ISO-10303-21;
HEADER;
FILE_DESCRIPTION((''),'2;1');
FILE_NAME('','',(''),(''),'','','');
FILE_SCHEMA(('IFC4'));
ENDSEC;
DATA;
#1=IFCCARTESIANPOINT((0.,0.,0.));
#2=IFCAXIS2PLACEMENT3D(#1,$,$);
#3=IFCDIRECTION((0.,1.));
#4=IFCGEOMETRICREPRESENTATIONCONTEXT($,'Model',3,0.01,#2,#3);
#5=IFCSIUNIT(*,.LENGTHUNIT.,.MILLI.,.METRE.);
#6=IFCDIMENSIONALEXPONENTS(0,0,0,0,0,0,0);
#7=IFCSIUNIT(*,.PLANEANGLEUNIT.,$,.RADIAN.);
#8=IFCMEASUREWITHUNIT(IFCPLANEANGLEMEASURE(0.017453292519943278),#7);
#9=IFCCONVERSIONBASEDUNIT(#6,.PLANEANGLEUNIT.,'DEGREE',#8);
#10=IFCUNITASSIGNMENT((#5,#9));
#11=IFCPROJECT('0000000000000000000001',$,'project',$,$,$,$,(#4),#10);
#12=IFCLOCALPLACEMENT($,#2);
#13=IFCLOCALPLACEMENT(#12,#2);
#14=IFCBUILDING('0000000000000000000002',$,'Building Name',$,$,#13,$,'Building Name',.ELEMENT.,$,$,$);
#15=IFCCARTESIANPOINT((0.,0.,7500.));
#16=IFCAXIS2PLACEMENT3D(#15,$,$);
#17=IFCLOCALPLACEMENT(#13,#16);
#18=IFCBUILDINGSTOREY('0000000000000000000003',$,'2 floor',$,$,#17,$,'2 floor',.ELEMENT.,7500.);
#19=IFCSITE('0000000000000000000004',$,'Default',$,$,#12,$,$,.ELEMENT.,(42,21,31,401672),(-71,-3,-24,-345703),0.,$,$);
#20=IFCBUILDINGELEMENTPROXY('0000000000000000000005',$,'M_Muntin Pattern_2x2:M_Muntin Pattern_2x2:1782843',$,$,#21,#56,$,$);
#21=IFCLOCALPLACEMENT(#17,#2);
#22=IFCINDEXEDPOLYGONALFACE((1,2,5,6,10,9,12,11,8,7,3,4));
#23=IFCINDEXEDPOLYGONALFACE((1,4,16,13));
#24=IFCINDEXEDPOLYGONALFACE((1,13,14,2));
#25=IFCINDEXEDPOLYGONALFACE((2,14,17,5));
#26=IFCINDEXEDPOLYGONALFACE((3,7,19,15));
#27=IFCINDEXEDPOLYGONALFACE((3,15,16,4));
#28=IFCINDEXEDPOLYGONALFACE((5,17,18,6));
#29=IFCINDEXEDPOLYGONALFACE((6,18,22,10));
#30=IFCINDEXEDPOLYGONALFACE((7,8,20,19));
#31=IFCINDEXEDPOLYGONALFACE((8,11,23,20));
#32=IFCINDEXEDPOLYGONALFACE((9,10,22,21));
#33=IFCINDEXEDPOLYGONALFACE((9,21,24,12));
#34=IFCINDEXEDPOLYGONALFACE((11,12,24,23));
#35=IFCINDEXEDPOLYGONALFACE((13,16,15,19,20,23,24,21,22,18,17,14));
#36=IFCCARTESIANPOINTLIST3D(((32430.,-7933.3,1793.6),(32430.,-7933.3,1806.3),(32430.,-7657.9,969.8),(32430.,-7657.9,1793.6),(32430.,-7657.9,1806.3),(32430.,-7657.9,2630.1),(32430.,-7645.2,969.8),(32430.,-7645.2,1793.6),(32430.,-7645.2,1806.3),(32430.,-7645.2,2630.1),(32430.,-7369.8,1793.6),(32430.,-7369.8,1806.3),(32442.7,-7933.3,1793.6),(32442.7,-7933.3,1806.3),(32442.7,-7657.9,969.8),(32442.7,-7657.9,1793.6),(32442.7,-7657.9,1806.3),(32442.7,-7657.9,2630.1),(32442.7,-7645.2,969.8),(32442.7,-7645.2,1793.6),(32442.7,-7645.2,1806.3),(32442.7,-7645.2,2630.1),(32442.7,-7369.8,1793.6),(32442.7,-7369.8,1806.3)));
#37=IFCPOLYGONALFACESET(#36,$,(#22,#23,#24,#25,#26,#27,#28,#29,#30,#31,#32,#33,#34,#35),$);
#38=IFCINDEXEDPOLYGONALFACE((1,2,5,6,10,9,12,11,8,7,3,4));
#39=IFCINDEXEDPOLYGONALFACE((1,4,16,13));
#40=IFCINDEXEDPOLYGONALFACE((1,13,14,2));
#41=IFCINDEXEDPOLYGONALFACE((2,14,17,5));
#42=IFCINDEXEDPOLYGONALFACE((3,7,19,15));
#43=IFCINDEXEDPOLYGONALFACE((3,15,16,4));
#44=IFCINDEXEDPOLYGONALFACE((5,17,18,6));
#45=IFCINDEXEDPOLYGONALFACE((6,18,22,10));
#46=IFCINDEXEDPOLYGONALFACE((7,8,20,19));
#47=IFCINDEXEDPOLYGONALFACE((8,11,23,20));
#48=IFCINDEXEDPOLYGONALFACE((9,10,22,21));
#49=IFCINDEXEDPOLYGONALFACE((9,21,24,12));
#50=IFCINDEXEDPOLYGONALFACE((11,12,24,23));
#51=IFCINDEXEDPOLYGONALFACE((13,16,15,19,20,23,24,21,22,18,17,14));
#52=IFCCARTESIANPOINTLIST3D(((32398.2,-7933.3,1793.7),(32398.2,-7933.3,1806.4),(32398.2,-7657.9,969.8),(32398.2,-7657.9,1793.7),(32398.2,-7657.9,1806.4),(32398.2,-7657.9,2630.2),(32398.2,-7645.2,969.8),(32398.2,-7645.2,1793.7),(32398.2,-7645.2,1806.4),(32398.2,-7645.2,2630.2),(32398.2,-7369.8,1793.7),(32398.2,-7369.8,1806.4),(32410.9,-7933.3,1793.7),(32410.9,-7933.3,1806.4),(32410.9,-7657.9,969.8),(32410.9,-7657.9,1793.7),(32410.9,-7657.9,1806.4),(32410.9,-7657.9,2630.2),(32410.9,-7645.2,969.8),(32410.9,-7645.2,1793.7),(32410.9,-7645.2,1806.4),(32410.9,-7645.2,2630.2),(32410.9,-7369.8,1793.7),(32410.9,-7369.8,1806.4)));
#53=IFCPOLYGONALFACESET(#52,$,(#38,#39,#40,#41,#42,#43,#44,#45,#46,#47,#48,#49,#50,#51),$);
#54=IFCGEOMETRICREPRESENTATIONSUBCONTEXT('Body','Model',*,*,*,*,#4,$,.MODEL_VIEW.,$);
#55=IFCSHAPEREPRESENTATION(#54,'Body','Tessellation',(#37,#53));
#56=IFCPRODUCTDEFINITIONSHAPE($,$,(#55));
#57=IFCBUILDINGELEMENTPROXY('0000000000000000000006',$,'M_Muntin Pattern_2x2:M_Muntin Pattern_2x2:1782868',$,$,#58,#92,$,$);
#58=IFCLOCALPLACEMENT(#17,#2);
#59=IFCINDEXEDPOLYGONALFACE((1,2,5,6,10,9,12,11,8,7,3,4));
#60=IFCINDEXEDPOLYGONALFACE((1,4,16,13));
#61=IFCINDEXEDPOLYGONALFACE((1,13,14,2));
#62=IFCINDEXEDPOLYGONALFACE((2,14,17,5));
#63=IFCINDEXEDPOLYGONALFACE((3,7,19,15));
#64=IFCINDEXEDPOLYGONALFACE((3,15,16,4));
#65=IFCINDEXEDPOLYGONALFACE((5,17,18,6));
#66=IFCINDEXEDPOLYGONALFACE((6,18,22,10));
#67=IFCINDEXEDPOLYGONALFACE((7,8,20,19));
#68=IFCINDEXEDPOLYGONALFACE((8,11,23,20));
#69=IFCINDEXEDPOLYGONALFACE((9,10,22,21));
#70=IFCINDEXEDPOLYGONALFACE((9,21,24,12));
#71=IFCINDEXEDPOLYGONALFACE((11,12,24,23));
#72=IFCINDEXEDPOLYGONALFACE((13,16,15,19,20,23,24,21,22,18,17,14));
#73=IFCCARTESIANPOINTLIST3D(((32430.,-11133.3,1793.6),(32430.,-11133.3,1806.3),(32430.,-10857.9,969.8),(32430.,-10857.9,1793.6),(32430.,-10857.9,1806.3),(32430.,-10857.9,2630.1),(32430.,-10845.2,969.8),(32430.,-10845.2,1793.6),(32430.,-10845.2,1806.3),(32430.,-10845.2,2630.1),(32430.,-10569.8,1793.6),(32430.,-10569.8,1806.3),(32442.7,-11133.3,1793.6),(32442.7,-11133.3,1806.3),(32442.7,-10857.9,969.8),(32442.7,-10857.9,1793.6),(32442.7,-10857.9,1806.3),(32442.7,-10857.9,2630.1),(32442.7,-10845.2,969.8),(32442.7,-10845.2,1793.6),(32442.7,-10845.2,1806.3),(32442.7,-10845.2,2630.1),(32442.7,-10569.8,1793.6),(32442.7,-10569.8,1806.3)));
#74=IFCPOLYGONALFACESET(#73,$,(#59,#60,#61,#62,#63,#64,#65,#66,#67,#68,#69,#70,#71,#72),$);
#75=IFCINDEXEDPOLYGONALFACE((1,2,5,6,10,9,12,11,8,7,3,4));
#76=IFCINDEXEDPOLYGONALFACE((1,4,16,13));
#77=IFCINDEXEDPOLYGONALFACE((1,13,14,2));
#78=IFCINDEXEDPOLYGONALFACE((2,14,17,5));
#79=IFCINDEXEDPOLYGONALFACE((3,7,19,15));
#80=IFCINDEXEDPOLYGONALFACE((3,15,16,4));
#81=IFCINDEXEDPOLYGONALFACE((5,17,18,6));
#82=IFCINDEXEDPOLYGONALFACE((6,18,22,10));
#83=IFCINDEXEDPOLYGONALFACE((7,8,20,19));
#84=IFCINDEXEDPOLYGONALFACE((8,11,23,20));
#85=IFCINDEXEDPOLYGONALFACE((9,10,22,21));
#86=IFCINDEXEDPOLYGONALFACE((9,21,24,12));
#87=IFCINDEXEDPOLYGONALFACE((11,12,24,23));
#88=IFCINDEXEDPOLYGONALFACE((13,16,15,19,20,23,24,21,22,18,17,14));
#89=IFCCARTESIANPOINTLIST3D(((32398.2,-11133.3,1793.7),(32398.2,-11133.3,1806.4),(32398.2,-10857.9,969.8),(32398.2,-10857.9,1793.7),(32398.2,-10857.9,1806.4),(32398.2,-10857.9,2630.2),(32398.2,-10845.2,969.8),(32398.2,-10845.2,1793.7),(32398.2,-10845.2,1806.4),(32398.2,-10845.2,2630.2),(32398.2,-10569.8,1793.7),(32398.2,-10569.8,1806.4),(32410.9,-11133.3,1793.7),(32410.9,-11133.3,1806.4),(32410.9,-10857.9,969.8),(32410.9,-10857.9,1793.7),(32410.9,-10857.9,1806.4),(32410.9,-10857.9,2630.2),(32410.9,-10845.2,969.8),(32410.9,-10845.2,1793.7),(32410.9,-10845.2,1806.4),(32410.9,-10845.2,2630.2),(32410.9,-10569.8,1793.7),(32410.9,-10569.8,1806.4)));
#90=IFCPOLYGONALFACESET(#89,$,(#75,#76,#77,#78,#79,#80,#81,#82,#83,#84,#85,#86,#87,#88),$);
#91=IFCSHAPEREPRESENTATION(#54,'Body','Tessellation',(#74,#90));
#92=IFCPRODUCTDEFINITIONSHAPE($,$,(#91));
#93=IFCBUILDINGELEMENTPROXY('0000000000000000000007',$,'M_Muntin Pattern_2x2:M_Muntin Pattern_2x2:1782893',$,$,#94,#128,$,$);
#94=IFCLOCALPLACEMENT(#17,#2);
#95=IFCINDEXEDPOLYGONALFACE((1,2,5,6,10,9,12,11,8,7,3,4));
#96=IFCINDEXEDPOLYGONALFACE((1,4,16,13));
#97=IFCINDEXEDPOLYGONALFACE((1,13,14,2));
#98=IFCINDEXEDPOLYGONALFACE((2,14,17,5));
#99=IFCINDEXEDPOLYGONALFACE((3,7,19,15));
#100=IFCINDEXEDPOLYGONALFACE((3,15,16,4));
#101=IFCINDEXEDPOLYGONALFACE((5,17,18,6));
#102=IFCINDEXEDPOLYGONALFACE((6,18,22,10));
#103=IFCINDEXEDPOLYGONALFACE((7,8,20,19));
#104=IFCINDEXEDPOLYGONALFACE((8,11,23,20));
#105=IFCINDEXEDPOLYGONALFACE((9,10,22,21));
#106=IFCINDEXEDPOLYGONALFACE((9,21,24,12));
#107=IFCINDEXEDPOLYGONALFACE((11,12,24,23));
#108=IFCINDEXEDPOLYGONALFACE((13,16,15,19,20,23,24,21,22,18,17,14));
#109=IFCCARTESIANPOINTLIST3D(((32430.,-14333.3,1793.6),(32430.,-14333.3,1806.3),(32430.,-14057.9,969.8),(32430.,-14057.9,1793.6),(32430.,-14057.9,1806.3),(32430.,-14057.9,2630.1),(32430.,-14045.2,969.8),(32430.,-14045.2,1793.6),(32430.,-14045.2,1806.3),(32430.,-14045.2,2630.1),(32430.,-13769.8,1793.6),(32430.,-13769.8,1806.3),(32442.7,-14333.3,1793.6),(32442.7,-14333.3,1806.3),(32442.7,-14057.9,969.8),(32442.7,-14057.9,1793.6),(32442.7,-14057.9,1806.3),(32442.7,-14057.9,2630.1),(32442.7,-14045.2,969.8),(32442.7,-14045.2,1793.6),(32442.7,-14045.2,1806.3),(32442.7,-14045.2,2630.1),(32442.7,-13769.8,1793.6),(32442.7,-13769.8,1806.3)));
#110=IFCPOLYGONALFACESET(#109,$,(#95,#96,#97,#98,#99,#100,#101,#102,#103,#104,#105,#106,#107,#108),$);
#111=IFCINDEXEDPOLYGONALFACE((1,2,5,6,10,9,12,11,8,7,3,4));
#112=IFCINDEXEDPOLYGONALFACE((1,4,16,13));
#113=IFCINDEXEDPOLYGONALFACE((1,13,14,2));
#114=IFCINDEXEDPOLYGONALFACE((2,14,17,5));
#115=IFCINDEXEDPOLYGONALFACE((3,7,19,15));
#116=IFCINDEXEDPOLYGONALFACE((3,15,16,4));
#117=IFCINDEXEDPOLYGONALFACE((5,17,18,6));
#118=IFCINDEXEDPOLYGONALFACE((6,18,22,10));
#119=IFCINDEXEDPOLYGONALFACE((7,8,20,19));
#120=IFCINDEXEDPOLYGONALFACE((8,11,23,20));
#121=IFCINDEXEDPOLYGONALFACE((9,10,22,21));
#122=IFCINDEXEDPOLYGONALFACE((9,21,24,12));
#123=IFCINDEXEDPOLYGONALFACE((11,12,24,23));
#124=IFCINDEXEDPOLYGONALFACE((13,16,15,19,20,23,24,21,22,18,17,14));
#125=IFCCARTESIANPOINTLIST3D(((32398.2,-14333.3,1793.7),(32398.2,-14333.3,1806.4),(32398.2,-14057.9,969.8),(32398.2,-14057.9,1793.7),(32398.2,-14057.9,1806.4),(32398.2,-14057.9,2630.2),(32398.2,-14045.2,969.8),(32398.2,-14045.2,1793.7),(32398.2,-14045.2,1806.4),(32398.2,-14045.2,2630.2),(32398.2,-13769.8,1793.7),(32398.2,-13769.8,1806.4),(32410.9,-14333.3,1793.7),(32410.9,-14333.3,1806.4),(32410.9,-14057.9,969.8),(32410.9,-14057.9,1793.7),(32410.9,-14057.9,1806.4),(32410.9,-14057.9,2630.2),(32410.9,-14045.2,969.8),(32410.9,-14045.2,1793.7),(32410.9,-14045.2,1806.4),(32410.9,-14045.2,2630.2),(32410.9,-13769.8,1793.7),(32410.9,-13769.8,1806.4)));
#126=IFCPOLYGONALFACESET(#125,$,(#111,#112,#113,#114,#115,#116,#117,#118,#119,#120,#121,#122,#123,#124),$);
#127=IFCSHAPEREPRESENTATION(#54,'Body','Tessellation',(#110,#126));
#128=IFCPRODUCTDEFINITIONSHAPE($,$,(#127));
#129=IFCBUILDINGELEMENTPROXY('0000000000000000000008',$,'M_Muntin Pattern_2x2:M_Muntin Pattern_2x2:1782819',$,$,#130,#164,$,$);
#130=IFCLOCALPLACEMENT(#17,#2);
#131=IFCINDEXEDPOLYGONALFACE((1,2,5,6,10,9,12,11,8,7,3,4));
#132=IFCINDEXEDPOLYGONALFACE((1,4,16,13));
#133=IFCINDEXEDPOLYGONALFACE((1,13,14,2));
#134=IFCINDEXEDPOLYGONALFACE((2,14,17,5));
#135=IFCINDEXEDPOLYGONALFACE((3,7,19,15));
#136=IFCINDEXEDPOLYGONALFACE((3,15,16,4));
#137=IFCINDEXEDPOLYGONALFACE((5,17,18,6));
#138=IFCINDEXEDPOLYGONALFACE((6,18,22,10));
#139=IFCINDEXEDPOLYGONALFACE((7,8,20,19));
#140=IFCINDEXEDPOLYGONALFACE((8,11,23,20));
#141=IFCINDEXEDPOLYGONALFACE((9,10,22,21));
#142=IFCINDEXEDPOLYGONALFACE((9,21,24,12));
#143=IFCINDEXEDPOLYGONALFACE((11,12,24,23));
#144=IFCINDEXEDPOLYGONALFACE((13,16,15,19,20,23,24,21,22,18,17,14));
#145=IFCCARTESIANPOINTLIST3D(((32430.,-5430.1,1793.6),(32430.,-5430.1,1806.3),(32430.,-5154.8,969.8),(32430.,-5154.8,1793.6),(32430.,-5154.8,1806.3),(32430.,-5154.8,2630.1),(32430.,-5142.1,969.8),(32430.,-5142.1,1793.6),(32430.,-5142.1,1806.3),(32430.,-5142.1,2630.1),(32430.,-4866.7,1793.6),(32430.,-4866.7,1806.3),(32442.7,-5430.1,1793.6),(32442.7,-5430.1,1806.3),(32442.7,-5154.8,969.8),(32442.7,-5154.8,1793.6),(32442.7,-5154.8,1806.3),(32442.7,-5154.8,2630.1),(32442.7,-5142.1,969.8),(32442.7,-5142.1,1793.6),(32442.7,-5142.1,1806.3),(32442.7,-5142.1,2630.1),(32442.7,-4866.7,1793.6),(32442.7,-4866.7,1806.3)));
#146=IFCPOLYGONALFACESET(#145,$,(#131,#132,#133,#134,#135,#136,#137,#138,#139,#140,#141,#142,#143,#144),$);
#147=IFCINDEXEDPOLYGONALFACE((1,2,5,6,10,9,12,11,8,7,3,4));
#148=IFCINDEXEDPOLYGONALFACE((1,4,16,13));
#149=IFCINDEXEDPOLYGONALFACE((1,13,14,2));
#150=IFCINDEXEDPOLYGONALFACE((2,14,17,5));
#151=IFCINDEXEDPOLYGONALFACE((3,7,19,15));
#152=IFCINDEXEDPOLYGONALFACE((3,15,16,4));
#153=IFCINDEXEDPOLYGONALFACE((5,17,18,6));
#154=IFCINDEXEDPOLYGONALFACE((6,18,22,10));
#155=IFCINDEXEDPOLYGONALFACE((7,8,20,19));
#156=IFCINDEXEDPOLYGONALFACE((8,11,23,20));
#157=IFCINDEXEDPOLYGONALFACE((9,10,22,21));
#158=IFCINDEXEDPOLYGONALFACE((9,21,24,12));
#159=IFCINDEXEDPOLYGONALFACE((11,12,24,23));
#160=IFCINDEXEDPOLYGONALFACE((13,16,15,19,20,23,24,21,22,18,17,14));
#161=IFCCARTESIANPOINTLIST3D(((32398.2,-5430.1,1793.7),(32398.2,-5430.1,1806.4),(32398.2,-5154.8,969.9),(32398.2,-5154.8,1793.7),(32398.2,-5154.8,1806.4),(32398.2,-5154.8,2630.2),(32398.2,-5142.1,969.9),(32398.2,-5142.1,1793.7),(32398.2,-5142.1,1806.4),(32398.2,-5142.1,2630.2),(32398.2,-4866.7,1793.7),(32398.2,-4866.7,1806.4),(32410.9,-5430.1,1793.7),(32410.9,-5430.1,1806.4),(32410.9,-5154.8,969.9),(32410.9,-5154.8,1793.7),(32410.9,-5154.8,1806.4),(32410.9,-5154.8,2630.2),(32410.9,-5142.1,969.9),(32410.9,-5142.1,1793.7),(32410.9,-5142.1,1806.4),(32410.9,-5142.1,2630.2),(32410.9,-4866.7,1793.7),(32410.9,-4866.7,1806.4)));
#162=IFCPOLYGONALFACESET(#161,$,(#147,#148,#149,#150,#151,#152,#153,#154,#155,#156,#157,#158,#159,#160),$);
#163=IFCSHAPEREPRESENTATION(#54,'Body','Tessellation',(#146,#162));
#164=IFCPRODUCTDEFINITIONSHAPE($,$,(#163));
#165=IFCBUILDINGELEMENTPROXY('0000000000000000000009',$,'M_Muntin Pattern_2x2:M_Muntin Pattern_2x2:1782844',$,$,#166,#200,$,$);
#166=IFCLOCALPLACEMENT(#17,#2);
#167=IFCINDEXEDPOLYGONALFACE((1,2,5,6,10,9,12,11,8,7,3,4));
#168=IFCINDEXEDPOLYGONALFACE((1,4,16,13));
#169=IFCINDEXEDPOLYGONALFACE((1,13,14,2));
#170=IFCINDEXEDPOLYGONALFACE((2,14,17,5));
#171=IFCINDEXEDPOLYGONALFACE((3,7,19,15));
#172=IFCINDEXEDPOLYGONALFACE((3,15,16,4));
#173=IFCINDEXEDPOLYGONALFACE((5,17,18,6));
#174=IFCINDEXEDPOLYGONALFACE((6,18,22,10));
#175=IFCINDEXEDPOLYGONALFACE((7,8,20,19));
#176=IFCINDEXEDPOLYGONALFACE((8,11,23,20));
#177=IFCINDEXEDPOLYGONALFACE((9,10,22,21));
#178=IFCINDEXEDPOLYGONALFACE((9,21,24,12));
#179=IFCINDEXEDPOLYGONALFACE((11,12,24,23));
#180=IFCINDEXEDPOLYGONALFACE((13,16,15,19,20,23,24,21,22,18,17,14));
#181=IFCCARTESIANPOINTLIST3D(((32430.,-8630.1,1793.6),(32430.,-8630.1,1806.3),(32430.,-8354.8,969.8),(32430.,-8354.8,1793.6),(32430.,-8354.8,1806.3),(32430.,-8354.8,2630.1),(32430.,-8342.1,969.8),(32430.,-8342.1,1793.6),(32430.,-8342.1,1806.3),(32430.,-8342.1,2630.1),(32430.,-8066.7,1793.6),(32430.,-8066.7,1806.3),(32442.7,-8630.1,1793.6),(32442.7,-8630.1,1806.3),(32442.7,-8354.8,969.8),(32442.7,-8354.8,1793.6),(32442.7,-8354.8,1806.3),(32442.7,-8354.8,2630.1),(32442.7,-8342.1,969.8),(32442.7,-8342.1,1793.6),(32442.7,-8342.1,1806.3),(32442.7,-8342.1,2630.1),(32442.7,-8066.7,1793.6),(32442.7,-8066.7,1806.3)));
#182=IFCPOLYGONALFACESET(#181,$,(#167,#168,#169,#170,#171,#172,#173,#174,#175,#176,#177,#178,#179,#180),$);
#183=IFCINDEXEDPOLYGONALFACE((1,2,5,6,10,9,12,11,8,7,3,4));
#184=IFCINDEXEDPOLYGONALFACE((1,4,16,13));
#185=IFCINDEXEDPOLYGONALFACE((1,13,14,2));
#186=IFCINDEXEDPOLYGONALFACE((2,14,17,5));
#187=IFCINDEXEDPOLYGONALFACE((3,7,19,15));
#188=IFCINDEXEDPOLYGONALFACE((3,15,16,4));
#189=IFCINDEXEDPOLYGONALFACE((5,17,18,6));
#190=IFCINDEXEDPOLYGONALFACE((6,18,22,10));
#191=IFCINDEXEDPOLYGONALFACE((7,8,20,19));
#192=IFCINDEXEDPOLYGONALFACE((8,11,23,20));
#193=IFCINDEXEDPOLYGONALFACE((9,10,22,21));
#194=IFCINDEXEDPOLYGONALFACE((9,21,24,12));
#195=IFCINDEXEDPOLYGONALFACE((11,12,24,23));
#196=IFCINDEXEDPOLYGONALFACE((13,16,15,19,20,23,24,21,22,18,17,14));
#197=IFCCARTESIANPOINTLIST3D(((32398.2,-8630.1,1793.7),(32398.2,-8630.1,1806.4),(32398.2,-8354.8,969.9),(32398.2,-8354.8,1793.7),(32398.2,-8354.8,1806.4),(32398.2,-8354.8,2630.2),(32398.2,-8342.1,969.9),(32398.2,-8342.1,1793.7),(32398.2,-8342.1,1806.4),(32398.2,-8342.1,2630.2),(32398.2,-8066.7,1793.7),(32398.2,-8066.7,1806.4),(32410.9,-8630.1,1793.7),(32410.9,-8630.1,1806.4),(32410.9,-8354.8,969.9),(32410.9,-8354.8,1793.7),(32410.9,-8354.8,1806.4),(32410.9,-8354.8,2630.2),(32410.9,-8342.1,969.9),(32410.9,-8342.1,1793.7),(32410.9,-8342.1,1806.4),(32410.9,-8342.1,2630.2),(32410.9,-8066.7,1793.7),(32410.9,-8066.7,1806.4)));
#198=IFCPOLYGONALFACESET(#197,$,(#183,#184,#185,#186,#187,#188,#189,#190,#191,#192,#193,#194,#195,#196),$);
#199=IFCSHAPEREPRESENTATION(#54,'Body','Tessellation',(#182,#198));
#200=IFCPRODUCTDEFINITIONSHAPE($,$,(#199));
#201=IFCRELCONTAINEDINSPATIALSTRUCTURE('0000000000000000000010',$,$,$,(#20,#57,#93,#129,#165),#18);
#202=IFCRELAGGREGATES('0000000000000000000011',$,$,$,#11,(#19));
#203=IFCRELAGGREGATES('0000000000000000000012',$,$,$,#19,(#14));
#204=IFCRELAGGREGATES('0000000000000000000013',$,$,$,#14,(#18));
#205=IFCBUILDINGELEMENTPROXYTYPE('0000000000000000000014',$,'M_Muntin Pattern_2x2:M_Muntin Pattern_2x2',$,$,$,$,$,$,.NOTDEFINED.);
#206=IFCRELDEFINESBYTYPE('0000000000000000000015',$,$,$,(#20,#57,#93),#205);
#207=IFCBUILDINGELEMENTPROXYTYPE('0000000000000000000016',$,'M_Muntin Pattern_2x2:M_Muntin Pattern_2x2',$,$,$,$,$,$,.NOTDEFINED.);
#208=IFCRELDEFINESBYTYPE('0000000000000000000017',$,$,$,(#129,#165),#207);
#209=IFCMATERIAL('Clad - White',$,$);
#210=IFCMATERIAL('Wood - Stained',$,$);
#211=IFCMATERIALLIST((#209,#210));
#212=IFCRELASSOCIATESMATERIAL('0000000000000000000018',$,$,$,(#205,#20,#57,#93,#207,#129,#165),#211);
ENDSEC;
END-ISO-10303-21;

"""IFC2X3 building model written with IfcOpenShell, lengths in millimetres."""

from ifc_helpers import new_model, entity, si_unit, converted_unit, direction, frame, origin, place, context, subcontext, project, spatial, polyline, outline, extrude, source, transform, mapped, material, material_list, type_object, type_shapes, element, save


model = new_model("IFC2X3")

# Units and contexts
model_context = context("Model", 3, precision=0.01, world=origin(), true_north=direction((0.0, 1.0)))
body_context = subcontext(model_context, "Body", "Model", "MODEL_VIEW")
ifc_project = project(units=[si_unit("LENGTHUNIT", "METRE", prefix="MILLI"), converted_unit("PLANEANGLEUNIT", "DEGREE", entity("IfcPlaneAngleMeasure", 0.017453292519943278), si_unit("PLANEANGLEUNIT", "RADIAN"), dimensions=[0, 0, 0, 0, 0, 0, 0])], contexts=[model_context])

# Site, building, storey
site_placement = place(None, origin())
site = spatial("IfcSite", under=ifc_project, at=site_placement, Name="Default", CompositionType="ELEMENT", RefLatitude=(42, 21, 31, 401672), RefLongitude=(-71, -3, -24, -345703), RefElevation=0.0)
building_placement = place(site_placement, origin())
building = spatial("IfcBuilding", under=site, at=building_placement, Name="Building Name", LongName="Building Name", CompositionType="ELEMENT")
storey_placement = place(building_placement, frame((0.0, 0.0, 7500.0)))
storey = spatial("IfcBuildingStorey", under=building, at=storey_placement, Name="2 floor", LongName="2 floor", CompositionType="ELEMENT", Elevation=7500.0)

# Building element proxies
ifc_material_1 = material(Name="Clad - White")
ifc_material_2 = material(Name="Wood - Stained")
ifc_material_list = material_list([ifc_material_1, ifc_material_2])
building_element_proxy_type_1 = type_object("IfcBuildingElementProxyType", Name="M_Muntin Pattern_2x2:M_Muntin Pattern_2x2", PredefinedType="NOTDEFINED", material=ifc_material_list)
shared_shape_1 = source(origin(), body_context, "Body", "SweptSolid", [
    extrude(outline(polyline([(6.4, -6.4), (830.1, -6.4), (830.1, 6.3), (6.4, 6.3), (6.4, 281.7), (-6.3, 281.7), (-6.3, 6.3), (-830.2, 6.3), (-830.2, -6.4), (-6.3, -6.4), (-6.3, -281.7), (6.4, -281.7), (6.4, -6.4)])), frame((0.0, 9.5, 830.1), z_axis=(0.0, 1.0, 0.0), x_axis=(0.0, 0.0, 1.0)), (0.0, 0.0, 1.0), 12.7),
    extrude(outline(polyline([(6.4, -6.4), (830.2, -6.4), (830.2, 6.3), (6.4, 6.3), (6.4, 281.7), (-6.3, 281.7), (-6.3, 6.3), (-830.2, 6.3), (-830.2, -6.4), (-6.3, -6.4), (-6.3, -281.7), (6.4, -281.7), (6.4, -6.4)])), frame((0.0, -22.2, 830.2), z_axis=(0.0, 1.0, 0.0), x_axis=(0.0, 0.0, 1.0)), (0.0, 0.0, 1.0), 12.7),
])
type_shapes(building_element_proxy_type_1, [shared_shape_1])
for number, where, z_axis, x_axis, name in (
    (1, (32420.5, -7651.6, 969.8), (0.0, 0.0, 1.0), (0.0, -1.0, 0.0), "M_Muntin Pattern_2x2:M_Muntin Pattern_2x2:1782843"),
    (2, (32420.5, -10851.6, 969.8), (0.0, 0.0, 1.0), (0.0, -1.0, 0.0), "M_Muntin Pattern_2x2:M_Muntin Pattern_2x2:1782868"),
    (3, (32420.5, -14051.6, 969.8), (0.0, 0.0, 1.0), (0.0, -1.0, 0.0), "M_Muntin Pattern_2x2:M_Muntin Pattern_2x2:1782893"),
):
    element("IfcBuildingElementProxy", number, at=place(storey_placement, frame(where, z_axis=z_axis, x_axis=x_axis)), inside=storey, type_object=building_element_proxy_type_1, material=ifc_material_list, Name=name, context=body_context, shape_type="MappedRepresentation", body=[
        mapped(shared_shape_1, transform((0.0, 0.0, 0.0), scale=1.0)),
    ])
building_element_proxy_type_2 = type_object("IfcBuildingElementProxyType", Name="M_Muntin Pattern_2x2:M_Muntin Pattern_2x2", PredefinedType="NOTDEFINED", material=ifc_material_list)
shared_shape_2 = source(origin(), body_context, "Body", "SweptSolid", [
    extrude(outline(polyline([(6.4, -6.4), (830.1, -6.4), (830.1, 6.3), (6.4, 6.3), (6.4, 281.7), (-6.3, 281.7), (-6.3, 6.3), (-830.2, 6.3), (-830.2, -6.4), (-6.3, -6.4), (-6.3, -281.7), (6.4, -281.7), (6.4, -6.4)])), frame((0.0, -22.2, 830.1), z_axis=(0.0, 1.0, 0.0), x_axis=(0.0, 0.0, 1.0)), (0.0, 0.0, 1.0), 12.7),
    extrude(outline(polyline([(6.4, -6.4), (830.2, -6.4), (830.2, 6.3), (6.4, 6.3), (6.4, 281.7), (-6.3, 281.7), (-6.3, 6.3), (-830.2, 6.3), (-830.2, -6.4), (-6.3, -6.4), (-6.3, -281.7), (6.4, -281.7), (6.4, -6.4)])), frame((0.0, 9.5, 830.2), z_axis=(0.0, 1.0, 0.0), x_axis=(0.0, 0.0, 1.0)), (0.0, 0.0, 1.0), 12.7),
])
type_shapes(building_element_proxy_type_2, [shared_shape_2])
for number, where, z_axis, x_axis, name in (
    (4, (32420.5, -5148.4, 969.9), (0.0, 0.0, 1.0), (0.0, 1.0, 0.0), "M_Muntin Pattern_2x2:M_Muntin Pattern_2x2:1782819"),
    (5, (32420.5, -8348.4, 969.9), (0.0, 0.0, 1.0), (0.0, 1.0, 0.0), "M_Muntin Pattern_2x2:M_Muntin Pattern_2x2:1782844"),
):
    element("IfcBuildingElementProxy", number, at=place(storey_placement, frame(where, z_axis=z_axis, x_axis=x_axis)), inside=storey, type_object=building_element_proxy_type_2, material=ifc_material_list, Name=name, context=body_context, shape_type="MappedRepresentation", body=[
        mapped(shared_shape_2, transform((0.0, 0.0, 0.0), scale=1.0)),
    ])

save(model, "model.ifc")
